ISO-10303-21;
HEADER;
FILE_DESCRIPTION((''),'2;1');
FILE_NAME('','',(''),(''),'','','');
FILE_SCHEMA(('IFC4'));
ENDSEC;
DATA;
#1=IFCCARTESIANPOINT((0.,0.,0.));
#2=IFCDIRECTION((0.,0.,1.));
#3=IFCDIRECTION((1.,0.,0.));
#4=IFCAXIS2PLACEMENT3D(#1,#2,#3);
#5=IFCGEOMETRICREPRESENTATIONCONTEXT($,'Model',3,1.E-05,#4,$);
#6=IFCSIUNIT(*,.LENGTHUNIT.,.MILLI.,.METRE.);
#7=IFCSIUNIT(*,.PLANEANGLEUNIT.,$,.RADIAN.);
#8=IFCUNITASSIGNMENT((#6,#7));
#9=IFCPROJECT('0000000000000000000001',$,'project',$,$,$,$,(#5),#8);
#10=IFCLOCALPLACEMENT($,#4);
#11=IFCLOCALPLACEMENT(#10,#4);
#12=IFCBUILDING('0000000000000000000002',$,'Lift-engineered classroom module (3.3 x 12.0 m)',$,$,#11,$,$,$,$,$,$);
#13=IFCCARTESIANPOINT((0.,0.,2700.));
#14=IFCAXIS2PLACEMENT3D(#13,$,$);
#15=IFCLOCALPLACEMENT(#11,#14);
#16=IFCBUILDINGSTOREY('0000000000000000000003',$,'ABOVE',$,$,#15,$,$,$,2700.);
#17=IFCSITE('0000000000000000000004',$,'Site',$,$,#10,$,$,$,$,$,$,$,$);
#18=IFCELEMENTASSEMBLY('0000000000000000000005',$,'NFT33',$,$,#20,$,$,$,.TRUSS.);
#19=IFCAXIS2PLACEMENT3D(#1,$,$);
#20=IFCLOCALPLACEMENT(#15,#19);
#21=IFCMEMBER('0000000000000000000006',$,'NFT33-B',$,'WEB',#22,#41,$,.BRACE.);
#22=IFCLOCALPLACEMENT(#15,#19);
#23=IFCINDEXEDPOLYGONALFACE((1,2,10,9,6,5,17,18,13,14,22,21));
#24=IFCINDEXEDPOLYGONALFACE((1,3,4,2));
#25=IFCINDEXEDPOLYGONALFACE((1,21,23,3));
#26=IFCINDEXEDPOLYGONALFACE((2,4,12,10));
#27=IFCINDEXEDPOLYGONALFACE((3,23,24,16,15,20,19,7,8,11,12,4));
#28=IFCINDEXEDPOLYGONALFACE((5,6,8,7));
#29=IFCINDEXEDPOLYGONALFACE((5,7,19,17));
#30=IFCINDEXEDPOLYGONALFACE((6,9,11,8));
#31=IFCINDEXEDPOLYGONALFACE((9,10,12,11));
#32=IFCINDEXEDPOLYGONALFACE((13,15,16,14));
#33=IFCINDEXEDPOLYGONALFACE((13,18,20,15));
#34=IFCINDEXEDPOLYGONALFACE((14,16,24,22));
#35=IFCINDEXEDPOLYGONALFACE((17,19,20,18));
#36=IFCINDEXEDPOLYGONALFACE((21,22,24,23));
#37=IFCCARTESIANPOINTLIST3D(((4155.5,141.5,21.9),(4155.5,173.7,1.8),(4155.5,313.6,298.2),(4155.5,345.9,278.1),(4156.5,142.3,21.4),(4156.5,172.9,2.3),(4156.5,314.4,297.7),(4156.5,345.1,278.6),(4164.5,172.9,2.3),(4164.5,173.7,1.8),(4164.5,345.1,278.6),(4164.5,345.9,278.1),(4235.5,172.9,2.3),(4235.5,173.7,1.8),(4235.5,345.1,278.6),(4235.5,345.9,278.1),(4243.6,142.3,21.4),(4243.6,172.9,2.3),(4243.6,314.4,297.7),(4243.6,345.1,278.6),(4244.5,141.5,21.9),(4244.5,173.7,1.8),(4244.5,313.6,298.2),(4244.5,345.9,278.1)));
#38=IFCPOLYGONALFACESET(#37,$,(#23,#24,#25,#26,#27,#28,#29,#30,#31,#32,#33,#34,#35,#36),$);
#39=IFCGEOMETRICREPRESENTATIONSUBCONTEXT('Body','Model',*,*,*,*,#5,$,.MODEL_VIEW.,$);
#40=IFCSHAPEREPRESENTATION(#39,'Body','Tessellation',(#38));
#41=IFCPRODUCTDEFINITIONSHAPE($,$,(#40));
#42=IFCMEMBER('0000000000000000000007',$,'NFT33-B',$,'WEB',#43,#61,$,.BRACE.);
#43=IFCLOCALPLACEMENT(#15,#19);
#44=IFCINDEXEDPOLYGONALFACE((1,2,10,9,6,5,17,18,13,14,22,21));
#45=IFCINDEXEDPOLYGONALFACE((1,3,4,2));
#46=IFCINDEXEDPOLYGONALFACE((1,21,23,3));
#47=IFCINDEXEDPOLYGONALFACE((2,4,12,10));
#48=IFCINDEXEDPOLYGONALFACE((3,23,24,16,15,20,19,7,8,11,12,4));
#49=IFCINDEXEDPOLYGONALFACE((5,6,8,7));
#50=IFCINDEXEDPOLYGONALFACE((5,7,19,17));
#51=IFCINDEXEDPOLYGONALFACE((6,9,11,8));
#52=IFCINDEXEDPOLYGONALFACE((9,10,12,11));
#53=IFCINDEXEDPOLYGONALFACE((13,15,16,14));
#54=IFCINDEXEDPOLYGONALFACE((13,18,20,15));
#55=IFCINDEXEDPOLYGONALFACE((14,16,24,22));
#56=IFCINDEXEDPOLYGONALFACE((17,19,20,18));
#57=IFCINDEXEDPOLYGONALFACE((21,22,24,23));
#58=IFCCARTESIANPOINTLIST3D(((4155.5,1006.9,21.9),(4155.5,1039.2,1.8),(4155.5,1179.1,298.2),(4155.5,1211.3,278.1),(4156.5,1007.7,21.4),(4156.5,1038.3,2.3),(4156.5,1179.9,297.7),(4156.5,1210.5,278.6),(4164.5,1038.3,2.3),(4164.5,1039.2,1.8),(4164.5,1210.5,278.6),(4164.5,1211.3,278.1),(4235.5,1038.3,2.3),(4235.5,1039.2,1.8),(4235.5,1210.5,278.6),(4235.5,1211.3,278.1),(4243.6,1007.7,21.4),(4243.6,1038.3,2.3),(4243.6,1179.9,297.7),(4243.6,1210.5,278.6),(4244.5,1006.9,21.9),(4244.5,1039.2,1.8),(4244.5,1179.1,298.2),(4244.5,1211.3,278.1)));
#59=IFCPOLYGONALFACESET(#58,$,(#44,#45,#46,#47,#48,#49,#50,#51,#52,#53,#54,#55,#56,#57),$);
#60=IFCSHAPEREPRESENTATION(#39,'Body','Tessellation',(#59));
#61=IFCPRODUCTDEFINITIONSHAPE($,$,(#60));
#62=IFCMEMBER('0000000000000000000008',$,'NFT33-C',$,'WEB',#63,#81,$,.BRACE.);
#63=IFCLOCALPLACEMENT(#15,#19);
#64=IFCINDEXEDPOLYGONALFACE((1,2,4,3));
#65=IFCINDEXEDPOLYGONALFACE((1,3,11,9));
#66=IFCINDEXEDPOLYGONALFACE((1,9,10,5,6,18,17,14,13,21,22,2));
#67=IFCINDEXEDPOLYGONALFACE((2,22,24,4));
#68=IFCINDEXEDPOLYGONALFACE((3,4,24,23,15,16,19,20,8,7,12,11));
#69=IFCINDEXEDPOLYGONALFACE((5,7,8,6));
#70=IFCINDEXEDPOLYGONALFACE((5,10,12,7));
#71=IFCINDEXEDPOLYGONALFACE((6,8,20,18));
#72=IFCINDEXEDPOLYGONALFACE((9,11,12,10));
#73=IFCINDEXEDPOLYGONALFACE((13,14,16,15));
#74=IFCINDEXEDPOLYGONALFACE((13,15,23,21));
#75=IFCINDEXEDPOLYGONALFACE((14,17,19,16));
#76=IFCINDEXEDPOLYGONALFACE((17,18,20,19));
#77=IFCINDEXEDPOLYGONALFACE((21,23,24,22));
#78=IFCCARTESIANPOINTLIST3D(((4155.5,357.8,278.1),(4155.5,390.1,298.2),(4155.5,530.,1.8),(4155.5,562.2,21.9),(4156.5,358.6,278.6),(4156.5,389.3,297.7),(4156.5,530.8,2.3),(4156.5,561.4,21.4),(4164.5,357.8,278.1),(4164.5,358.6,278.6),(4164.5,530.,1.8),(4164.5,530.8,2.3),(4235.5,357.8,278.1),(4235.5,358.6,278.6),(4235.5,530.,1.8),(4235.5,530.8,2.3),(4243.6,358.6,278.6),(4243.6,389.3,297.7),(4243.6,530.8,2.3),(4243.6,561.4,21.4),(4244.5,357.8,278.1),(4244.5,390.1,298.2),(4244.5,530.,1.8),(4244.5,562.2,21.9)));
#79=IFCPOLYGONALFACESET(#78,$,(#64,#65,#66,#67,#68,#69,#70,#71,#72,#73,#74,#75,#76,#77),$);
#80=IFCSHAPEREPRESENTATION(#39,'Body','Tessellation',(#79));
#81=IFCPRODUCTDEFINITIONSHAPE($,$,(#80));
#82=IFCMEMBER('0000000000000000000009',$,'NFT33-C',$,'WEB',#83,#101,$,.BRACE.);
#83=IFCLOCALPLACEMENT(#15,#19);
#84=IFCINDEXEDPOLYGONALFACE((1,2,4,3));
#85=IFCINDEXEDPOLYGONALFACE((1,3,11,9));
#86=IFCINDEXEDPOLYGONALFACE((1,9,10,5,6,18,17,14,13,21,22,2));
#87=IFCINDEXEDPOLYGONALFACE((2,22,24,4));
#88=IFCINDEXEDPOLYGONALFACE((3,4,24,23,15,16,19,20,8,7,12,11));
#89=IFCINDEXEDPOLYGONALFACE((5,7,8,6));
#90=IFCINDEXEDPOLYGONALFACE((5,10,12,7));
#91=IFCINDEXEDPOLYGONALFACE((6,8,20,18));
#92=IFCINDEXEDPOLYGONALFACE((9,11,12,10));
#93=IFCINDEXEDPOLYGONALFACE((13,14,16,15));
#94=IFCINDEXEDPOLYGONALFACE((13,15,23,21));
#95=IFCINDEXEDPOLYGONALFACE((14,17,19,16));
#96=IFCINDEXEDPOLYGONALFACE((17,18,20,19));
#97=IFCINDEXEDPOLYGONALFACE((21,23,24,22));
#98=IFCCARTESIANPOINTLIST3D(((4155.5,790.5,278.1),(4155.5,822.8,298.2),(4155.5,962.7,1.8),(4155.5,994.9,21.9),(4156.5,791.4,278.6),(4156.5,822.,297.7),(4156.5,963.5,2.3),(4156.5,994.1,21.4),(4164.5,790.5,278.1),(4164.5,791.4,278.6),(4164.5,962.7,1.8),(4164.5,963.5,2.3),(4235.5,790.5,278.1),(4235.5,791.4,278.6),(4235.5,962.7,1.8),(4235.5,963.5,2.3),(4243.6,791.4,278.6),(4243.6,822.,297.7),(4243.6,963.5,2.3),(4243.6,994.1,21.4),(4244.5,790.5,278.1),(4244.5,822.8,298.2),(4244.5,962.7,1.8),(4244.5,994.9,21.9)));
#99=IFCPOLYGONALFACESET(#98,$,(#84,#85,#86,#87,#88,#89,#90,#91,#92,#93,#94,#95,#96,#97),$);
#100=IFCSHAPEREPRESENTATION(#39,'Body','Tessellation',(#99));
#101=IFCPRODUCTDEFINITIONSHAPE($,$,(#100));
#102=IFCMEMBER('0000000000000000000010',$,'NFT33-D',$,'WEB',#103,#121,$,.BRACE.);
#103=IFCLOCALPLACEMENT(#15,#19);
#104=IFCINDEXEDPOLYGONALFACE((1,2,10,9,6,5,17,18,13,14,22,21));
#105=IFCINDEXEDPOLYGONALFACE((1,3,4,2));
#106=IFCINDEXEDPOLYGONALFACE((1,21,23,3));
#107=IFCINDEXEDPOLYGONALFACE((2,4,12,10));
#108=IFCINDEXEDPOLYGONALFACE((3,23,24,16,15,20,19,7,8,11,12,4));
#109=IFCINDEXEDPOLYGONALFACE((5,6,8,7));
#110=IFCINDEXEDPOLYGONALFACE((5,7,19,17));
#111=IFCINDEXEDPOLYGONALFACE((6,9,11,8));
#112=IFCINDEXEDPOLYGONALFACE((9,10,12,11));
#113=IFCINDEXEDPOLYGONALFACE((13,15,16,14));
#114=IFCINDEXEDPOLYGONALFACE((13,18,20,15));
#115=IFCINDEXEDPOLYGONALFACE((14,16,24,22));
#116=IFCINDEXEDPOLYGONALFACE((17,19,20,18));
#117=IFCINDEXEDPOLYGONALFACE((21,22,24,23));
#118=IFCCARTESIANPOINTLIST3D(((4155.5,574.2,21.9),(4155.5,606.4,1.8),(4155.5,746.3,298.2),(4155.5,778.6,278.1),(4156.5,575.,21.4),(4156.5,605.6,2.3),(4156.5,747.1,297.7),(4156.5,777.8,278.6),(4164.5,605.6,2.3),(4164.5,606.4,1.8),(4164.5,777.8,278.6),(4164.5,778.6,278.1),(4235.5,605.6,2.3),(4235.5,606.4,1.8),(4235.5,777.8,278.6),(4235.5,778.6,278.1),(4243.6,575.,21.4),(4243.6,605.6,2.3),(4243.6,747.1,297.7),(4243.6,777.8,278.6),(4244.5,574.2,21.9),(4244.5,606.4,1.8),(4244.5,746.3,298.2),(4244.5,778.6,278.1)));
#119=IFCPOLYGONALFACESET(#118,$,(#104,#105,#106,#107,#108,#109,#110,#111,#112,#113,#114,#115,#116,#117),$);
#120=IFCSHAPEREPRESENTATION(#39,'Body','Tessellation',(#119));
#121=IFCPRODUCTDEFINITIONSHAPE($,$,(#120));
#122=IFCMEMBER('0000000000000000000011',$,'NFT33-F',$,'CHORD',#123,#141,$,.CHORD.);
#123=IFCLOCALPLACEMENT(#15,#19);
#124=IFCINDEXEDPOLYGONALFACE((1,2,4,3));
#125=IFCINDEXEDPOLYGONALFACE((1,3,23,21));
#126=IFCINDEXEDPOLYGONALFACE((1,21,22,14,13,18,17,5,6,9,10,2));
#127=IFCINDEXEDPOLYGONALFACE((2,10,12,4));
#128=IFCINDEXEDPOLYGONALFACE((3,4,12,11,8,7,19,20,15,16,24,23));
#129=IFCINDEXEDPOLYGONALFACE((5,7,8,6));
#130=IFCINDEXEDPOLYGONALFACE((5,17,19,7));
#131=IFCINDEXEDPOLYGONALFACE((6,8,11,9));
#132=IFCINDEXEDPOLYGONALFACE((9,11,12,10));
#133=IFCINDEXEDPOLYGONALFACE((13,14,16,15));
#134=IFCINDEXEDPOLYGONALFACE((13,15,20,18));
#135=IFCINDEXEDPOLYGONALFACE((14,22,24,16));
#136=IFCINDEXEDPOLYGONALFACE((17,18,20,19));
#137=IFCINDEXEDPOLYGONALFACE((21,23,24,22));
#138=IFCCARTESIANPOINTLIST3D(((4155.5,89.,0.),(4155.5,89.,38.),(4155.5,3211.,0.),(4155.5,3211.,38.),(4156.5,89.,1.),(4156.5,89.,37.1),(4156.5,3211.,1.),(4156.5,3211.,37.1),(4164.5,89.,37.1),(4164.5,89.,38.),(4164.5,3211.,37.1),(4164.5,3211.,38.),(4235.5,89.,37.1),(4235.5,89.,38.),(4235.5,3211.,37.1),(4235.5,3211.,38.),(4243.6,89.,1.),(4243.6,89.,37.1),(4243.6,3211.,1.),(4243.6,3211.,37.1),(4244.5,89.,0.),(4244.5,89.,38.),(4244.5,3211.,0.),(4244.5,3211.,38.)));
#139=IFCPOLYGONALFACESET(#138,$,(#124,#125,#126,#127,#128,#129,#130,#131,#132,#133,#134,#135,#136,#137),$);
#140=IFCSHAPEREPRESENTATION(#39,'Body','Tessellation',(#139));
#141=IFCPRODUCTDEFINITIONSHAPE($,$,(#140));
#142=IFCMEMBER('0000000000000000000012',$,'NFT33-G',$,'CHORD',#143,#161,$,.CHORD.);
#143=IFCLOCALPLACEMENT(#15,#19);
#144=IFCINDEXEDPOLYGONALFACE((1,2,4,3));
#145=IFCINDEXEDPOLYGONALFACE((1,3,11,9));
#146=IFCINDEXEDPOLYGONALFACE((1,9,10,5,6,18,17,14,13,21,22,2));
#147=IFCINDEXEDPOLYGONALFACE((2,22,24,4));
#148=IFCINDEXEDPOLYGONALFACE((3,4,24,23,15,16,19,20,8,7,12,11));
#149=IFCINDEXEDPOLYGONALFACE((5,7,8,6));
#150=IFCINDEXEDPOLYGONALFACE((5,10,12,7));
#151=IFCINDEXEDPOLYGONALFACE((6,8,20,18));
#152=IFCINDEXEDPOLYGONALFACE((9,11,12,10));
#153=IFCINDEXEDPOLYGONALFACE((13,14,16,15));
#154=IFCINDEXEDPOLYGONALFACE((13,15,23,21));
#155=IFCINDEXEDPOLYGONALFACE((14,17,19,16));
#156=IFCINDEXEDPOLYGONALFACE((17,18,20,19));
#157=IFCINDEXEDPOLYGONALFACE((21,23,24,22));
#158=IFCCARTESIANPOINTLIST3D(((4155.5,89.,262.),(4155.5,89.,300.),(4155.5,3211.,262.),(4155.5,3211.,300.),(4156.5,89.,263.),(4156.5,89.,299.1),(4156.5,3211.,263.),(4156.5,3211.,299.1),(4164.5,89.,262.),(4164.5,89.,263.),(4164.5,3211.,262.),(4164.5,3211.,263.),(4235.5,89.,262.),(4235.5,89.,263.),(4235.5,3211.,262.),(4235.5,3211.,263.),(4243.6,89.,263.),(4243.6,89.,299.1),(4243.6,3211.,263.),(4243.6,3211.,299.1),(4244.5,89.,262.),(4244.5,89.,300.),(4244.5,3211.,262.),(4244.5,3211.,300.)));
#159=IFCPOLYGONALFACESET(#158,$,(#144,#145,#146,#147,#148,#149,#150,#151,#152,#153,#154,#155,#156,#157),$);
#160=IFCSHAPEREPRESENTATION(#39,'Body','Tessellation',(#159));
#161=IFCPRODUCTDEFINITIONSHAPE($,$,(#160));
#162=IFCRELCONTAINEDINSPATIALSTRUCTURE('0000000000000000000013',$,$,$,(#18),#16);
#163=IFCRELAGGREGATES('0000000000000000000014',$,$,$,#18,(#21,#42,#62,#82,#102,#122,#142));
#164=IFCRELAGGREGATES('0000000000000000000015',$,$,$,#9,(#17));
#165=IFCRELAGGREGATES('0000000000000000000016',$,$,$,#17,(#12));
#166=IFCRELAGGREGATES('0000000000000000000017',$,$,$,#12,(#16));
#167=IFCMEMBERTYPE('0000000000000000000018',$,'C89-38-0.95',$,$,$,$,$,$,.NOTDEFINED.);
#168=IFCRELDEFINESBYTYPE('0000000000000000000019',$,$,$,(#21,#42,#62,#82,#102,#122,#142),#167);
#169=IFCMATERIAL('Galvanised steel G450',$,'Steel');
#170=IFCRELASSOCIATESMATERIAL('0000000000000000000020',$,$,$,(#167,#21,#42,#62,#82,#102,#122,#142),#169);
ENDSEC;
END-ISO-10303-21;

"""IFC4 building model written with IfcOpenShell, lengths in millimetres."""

from ifc_helpers import new_model, si_unit, frame, origin, origin_with_axes, origin_2d, place, context, subcontext, project, spatial, c_section, extrude, material, material_profile, profile_set, profile_usage, type_object, element, aggregate, save


model = new_model("IFC4")

# Units and contexts
model_context = context("Model", 3, precision=1e-05, world=origin_with_axes())
body_context = subcontext(model_context, "Body", "Model", "MODEL_VIEW")
ifc_project = project(units=[si_unit("LENGTHUNIT", "METRE", prefix="MILLI"), si_unit("PLANEANGLEUNIT", "RADIAN")], contexts=[model_context])

# Site, building, storey
site_placement = place(None, origin_with_axes())
site = spatial("IfcSite", under=ifc_project, at=site_placement, Name="Site")
building_placement = place(site_placement, origin_with_axes())
building = spatial("IfcBuilding", under=site, at=building_placement, Name="Lift-engineered classroom module (3.3 x 12.0 m)")
storey_placement = place(building_placement, frame((0.0, 0.0, 2700.0)))
storey = spatial("IfcBuildingStorey", under=building, at=storey_placement, Name="ABOVE", Elevation=2700.0)

# Element assembly, members
ifc_material = material(Name="Galvanised steel G450", Category="Steel")
ifc_material_profile = material_profile(ifc_material, c_section(Depth=89.0, Width=38.0, WallThickness=0.9, Girth=9.0, at=origin_2d()), Name="C89-38-0.95")
ifc_profile_set = profile_set([ifc_material_profile], Name="C89-38-0.95")
ifc_profile_usage = profile_usage(ifc_profile_set)
member_type = type_object("IfcMemberType", Name="C89-38-0.95", PredefinedType="NOTDEFINED", material=ifc_profile_set)
assembly_1_placement = place(storey_placement, frame((4200.0, 89.0, 0.0)))
assembly_1 = element("IfcElementAssembly", 1, at=assembly_1_placement, inside=storey, Name="NFT33", PredefinedType="TRUSS")
member_1_placement = place(assembly_1_placement, frame((0.0, 68.6, 11.8), z_axis=(0.0, 0.528797, 0.848748), x_axis=(0.0, 0.848748, -0.528797)))
member_1 = element("IfcMember", 2, at=member_1_placement, type_object=member_type, material=ifc_profile_usage, Name="NFT33-B", ObjectType="WEB", PredefinedType="BRACE", context=body_context, shape_type="SweptSolid", body=[
    extrude(c_section(Depth=89.0, Width=38.0, WallThickness=0.9, Girth=9.0, at=origin_2d()), origin(), (0.0, 0.0, 1.0), 325.6),
])
member_2_placement = place(assembly_1_placement, frame((0.0, 934.0, 11.8), z_axis=(0.0, 0.528797, 0.848748), x_axis=(0.0, 0.848748, -0.528797)))
member_2 = element("IfcMember", 3, at=member_2_placement, type_object=member_type, material=ifc_profile_usage, Name="NFT33-B", ObjectType="WEB", PredefinedType="BRACE", context=body_context, shape_type="SweptSolid", body=[
    extrude(c_section(Depth=89.0, Width=38.0, WallThickness=0.9, Girth=9.0, at=origin_2d()), origin(), (0.0, 0.0, 1.0), 325.6),
])
member_3_placement = place(assembly_1_placement, frame((0.0, 457.1, 11.8), z_axis=(0.0, -0.528797, 0.848748), x_axis=(0.0, -0.848748, -0.528797)))
member_3 = element("IfcMember", 4, at=member_3_placement, type_object=member_type, material=ifc_profile_usage, Name="NFT33-C", ObjectType="WEB", PredefinedType="BRACE", context=body_context, shape_type="SweptSolid", body=[
    extrude(c_section(Depth=89.0, Width=38.0, WallThickness=0.9, Girth=9.0, at=origin_2d()), origin(), (0.0, 0.0, 1.0), 325.6),
])
member_4_placement = place(assembly_1_placement, frame((0.0, 889.8, 11.8), z_axis=(0.0, -0.528797, 0.848748), x_axis=(0.0, -0.848748, -0.528797)))
member_4 = element("IfcMember", 5, at=member_4_placement, type_object=member_type, material=ifc_profile_usage, Name="NFT33-C", ObjectType="WEB", PredefinedType="BRACE", context=body_context, shape_type="SweptSolid", body=[
    extrude(c_section(Depth=89.0, Width=38.0, WallThickness=0.9, Girth=9.0, at=origin_2d()), origin(), (0.0, 0.0, 1.0), 325.6),
])
member_5_placement = place(assembly_1_placement, frame((0.0, 501.3, 11.8), z_axis=(0.0, 0.528775, 0.848762), x_axis=(0.0, 0.848762, -0.528775)))
member_5 = element("IfcMember", 6, at=member_5_placement, type_object=member_type, material=ifc_profile_usage, Name="NFT33-D", ObjectType="WEB", PredefinedType="BRACE", context=body_context, shape_type="SweptSolid", body=[
    extrude(c_section(Depth=89.0, Width=38.0, WallThickness=0.9, Girth=9.0, at=origin_2d()), origin(), (0.0, 0.0, 1.0), 325.6),
])
member_6_placement = place(assembly_1_placement, frame((0.0, 0.0, 19.0), z_axis=(0.0, 1.0, 0.0), x_axis=(0.0, 0.0, 1.0)))
member_6 = element("IfcMember", 7, at=member_6_placement, type_object=member_type, material=ifc_profile_usage, Name="NFT33-F", ObjectType="CHORD", PredefinedType="CHORD", context=body_context, shape_type="SweptSolid", body=[
    extrude(c_section(Depth=89.0, Width=38.0, WallThickness=0.9, Girth=9.0, at=origin_2d()), origin(), (0.0, 0.0, 1.0), 3122.0),
])
member_7_placement = place(assembly_1_placement, frame((0.0, 0.0, 281.0), z_axis=(0.0, 1.0, 0.0), x_axis=(0.0, 0.0, -1.0)))
member_7 = element("IfcMember", 8, at=member_7_placement, type_object=member_type, material=ifc_profile_usage, Name="NFT33-G", ObjectType="CHORD", PredefinedType="CHORD", context=body_context, shape_type="SweptSolid", body=[
    extrude(c_section(Depth=89.0, Width=38.0, WallThickness=0.9, Girth=9.0, at=origin_2d()), origin(), (0.0, 0.0, 1.0), 3122.0),
])
aggregate(assembly_1, [member_1, member_2, member_3, member_4, member_5, member_6, member_7])

save(model, "model.ifc")
